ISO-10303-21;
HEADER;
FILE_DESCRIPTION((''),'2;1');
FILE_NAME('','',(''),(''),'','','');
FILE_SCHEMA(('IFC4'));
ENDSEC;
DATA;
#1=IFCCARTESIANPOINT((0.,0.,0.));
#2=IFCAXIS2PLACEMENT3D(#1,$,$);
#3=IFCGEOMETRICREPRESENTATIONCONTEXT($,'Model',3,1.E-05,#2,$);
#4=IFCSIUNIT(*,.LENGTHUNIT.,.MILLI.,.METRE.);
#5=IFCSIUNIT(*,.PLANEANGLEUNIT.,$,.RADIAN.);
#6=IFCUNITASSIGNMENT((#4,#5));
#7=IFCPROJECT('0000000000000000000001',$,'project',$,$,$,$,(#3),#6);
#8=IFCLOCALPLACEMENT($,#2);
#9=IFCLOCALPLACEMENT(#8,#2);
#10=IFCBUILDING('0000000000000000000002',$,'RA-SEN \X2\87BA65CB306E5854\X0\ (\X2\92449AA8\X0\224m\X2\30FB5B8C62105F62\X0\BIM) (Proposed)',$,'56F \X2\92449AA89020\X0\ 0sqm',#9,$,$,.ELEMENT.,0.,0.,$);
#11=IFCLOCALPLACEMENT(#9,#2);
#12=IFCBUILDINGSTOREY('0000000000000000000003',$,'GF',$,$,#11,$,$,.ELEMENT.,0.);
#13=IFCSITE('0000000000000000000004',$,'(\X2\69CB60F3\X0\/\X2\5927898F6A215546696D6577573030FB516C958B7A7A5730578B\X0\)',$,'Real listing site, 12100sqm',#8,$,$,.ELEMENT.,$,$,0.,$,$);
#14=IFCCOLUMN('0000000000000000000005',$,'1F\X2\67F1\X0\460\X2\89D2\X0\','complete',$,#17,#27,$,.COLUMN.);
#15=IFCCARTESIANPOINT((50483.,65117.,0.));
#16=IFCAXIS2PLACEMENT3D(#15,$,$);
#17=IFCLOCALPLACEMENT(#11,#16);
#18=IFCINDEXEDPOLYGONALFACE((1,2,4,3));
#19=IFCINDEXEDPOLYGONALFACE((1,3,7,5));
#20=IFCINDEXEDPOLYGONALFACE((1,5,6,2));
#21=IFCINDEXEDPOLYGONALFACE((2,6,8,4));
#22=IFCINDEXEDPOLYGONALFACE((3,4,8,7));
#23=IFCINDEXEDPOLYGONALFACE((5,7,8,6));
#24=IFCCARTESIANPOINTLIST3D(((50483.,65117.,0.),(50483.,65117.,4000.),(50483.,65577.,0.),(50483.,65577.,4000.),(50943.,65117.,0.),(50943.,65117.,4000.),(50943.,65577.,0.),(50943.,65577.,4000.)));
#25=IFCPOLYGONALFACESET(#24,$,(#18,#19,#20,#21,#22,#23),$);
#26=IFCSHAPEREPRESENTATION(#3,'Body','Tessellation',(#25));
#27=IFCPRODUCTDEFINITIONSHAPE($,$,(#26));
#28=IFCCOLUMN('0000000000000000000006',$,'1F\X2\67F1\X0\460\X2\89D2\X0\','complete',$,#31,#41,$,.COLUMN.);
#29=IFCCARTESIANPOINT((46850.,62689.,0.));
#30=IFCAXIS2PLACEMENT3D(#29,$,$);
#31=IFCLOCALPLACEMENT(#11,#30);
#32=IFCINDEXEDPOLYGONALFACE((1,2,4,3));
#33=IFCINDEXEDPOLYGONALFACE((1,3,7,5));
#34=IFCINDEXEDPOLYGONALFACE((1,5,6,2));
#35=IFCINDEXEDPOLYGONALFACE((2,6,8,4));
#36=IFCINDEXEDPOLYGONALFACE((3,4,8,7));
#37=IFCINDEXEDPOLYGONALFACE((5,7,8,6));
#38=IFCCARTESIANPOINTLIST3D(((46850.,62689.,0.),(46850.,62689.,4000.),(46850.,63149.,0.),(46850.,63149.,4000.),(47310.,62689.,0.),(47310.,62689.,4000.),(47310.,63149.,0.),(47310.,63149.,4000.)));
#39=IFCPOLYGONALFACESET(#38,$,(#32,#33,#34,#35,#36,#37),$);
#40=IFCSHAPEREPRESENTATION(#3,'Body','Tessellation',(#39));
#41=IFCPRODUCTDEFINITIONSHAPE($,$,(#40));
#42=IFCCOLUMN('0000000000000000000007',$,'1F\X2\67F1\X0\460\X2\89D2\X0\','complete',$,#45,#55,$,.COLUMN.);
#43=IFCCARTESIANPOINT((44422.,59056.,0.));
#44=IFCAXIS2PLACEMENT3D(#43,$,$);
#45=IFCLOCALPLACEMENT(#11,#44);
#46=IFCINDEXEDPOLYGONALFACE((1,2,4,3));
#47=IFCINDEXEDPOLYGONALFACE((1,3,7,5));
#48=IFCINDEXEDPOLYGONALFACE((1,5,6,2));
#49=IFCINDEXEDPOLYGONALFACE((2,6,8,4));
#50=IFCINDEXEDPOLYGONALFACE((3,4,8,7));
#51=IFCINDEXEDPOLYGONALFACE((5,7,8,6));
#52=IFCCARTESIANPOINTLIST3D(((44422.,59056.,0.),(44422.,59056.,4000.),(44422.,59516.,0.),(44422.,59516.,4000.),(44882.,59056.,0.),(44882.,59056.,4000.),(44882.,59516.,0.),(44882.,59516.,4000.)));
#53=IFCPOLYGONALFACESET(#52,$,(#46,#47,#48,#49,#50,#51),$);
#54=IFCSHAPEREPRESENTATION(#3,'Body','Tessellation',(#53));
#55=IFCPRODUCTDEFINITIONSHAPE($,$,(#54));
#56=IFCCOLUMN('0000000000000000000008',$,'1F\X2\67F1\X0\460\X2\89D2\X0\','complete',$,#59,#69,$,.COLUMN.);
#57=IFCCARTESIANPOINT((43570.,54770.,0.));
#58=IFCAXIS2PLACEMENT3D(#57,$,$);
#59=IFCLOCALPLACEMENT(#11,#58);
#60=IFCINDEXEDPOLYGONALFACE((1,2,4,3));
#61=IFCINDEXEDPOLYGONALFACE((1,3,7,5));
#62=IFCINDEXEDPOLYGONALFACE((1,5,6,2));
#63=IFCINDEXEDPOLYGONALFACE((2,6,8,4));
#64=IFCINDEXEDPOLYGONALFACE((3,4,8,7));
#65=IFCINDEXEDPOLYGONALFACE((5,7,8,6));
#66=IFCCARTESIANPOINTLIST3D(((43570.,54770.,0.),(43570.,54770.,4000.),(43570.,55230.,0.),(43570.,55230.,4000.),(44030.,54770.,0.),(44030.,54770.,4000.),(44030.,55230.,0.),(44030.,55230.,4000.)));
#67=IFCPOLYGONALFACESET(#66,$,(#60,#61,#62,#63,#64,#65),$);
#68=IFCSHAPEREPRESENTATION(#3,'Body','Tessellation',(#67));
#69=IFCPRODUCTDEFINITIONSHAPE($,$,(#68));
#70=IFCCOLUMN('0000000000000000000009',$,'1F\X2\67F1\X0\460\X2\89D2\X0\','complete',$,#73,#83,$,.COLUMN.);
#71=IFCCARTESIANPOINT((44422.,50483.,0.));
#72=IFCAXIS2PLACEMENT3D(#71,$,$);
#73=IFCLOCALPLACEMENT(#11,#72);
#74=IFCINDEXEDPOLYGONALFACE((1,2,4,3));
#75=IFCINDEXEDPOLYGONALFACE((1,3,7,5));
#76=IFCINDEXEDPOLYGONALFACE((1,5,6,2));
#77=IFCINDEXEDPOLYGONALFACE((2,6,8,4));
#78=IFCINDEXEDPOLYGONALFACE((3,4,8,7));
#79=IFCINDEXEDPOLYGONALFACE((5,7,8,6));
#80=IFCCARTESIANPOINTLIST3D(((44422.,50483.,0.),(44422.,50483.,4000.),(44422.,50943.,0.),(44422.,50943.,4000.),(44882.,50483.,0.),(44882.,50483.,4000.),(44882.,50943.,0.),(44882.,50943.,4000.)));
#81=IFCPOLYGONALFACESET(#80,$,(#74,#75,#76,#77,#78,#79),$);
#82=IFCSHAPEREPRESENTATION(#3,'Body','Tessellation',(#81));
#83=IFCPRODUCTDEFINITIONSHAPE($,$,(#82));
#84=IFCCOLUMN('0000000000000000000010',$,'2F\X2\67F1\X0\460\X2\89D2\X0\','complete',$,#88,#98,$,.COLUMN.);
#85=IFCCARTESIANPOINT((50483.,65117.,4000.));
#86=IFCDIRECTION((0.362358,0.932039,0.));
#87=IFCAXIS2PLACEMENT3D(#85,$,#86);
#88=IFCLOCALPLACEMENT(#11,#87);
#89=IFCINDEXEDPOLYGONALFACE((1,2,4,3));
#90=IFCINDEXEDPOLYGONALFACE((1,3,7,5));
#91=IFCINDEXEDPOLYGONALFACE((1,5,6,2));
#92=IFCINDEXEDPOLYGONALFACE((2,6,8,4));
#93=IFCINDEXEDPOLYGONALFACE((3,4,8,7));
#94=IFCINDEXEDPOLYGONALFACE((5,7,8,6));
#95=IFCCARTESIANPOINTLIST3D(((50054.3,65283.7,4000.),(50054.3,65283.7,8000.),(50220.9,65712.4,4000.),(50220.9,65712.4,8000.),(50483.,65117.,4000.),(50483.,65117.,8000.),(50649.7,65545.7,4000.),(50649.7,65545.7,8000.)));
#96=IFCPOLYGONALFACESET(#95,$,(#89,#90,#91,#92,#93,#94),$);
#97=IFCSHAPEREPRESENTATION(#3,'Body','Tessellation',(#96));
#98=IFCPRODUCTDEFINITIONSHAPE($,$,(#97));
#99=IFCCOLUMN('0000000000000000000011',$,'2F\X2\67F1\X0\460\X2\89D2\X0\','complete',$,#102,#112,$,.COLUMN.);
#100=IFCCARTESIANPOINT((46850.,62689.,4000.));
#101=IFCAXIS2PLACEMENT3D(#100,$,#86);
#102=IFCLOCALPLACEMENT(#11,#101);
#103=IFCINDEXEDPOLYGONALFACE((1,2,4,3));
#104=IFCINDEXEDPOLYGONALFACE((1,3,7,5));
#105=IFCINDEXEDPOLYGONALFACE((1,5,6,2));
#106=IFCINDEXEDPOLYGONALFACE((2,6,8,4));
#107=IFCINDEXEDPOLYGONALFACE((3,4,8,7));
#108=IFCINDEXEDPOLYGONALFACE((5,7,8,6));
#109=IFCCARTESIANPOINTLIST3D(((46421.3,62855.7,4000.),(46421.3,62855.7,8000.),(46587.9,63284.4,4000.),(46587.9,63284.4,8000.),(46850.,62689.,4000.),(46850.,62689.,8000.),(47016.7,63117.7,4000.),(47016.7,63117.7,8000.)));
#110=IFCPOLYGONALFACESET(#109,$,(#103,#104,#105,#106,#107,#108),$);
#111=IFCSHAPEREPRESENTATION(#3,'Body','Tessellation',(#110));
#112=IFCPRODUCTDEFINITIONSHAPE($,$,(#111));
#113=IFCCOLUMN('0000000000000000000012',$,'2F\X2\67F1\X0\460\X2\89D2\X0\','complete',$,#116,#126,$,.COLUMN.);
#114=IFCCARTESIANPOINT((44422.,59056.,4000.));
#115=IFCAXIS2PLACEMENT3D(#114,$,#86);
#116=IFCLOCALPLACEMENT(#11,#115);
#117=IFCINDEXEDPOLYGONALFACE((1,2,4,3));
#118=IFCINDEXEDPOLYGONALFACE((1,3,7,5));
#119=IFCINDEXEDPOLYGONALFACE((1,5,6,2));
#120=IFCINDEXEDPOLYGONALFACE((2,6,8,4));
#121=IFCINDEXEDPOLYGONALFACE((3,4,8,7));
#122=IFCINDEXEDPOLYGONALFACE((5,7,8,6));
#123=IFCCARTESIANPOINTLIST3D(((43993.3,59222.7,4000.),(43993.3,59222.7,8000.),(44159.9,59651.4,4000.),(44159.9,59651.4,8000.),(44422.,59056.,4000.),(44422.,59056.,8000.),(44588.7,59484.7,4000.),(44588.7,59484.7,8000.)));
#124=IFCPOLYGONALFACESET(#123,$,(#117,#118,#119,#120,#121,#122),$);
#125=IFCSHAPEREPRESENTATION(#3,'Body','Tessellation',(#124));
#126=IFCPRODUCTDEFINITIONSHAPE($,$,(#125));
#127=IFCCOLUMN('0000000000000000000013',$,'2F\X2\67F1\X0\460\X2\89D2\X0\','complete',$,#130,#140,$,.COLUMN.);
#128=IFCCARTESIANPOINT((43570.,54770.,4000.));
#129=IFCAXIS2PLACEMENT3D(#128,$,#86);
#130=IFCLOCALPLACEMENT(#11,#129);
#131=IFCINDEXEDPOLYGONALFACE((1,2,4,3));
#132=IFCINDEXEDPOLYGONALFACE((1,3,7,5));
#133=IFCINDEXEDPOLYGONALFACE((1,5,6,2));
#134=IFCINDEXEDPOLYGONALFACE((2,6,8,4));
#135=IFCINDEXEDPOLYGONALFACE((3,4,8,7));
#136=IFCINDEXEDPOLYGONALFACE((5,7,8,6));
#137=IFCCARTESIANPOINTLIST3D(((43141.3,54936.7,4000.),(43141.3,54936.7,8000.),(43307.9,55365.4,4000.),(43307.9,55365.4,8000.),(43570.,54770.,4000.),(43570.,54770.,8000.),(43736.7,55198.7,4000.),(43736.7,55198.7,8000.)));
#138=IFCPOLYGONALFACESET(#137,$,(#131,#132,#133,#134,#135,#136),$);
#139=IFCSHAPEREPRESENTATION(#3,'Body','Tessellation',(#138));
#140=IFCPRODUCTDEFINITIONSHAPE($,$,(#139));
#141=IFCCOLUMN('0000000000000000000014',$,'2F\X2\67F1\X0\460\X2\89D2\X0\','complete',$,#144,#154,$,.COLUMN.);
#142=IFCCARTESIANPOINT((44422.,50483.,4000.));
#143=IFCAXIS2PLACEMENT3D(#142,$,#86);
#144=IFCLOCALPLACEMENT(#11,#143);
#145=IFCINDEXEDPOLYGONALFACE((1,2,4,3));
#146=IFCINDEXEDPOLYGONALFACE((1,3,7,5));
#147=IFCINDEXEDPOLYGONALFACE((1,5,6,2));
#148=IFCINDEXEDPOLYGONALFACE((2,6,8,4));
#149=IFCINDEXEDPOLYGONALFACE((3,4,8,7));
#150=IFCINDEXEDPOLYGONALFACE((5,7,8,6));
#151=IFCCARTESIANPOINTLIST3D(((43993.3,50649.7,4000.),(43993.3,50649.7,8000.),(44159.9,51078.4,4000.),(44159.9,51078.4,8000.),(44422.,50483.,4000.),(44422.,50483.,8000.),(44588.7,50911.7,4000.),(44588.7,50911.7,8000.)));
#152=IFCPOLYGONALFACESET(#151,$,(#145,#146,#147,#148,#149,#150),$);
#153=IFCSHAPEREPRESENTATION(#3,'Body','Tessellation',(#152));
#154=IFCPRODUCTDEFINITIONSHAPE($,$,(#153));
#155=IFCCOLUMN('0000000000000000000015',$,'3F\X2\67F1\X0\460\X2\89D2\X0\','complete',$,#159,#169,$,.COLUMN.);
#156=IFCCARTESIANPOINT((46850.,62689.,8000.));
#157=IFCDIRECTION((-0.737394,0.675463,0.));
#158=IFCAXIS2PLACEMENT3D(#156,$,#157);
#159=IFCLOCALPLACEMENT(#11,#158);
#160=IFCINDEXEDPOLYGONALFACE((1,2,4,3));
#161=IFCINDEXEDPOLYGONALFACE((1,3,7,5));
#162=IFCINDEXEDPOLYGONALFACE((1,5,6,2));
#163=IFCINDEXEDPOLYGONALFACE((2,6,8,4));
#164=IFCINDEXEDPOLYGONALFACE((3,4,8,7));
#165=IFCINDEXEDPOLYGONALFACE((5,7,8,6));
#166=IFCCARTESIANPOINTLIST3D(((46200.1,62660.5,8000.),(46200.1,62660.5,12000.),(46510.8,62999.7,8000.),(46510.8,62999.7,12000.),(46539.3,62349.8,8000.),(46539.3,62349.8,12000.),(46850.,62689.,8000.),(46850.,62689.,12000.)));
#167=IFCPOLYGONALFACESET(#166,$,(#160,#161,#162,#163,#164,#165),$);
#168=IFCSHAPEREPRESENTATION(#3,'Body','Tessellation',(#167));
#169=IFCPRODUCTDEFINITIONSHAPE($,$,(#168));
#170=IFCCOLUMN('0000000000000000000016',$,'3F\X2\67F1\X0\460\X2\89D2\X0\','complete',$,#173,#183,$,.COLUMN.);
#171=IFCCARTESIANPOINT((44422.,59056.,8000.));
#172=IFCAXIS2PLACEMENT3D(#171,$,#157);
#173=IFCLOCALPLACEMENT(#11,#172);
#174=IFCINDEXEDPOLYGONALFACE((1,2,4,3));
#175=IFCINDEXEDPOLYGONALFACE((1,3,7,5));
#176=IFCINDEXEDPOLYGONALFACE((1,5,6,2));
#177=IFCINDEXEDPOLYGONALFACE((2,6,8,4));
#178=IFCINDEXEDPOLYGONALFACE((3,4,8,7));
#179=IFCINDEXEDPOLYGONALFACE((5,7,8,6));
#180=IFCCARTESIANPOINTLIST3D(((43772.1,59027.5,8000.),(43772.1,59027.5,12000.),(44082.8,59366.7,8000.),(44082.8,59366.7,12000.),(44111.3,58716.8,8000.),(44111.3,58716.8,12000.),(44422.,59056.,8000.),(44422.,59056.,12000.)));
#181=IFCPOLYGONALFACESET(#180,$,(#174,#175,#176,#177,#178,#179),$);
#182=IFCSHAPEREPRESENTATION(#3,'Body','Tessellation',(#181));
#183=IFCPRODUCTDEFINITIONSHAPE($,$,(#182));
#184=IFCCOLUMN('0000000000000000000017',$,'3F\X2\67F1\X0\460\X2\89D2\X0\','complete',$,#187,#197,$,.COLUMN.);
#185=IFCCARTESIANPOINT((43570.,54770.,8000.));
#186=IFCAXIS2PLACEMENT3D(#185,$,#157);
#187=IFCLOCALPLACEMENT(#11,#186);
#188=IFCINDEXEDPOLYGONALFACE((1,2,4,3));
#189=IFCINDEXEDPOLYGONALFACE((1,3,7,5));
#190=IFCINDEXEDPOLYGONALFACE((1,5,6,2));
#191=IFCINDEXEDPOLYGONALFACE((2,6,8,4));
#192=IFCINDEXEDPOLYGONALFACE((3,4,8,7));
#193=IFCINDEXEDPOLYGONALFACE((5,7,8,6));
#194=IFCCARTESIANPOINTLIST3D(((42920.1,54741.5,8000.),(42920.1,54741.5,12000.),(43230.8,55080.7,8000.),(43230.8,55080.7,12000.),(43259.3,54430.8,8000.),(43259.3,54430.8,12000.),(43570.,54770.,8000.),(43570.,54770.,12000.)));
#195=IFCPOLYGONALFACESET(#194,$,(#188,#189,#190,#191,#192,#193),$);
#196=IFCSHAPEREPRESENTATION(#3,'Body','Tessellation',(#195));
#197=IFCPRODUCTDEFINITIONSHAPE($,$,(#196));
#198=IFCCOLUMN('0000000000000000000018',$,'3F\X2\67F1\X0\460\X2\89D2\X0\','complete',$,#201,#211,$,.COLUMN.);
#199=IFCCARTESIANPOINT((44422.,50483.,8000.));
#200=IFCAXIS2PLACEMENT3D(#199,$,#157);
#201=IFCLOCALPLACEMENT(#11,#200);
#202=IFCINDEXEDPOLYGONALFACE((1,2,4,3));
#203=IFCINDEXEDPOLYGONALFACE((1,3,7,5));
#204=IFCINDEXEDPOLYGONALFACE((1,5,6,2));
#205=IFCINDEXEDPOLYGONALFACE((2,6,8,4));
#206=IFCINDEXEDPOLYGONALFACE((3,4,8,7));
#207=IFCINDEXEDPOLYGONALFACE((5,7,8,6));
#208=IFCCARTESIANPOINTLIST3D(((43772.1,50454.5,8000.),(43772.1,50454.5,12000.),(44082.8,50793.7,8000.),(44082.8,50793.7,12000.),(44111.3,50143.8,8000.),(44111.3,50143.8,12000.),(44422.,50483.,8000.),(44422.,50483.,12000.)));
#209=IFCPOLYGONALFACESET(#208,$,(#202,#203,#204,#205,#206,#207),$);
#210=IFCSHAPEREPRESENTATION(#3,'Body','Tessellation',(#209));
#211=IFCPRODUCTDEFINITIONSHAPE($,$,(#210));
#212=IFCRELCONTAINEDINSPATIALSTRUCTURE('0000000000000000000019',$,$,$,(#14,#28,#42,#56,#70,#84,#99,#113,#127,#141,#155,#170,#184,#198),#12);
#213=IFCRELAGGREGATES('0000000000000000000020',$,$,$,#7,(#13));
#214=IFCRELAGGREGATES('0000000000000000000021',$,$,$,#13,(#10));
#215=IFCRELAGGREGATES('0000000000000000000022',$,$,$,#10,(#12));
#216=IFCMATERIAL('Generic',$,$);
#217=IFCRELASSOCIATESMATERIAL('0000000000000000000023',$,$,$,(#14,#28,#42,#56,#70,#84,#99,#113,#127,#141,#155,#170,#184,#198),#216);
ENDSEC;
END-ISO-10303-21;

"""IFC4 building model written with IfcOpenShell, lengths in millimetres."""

from ifc_helpers import new_model, si_unit, frame, frame_2d, origin, place, context, project, spatial, rectangle, extrude, material, element, save


model = new_model("IFC4")

# Units and contexts
model_context = context("Model", 3, precision=1e-05, world=origin())
ifc_project = project(units=[si_unit("LENGTHUNIT", "METRE", prefix="MILLI"), si_unit("PLANEANGLEUNIT", "RADIAN")], contexts=[model_context])

# Site, building, storey
site_placement = place(None, origin())
site = spatial("IfcSite", under=ifc_project, at=site_placement, Name="(構想/大規模商業敷地・公開空地型)", ObjectType="Real listing site, 12100sqm", CompositionType="ELEMENT", RefElevation=0.0)
building_placement = place(site_placement, origin())
building = spatial("IfcBuilding", under=site, at=building_placement, Name="RA-SEN 螺旋の塔 (鉄骨224m・完成形BIM) (Proposed)", ObjectType="56F 鉄骨造 0sqm", CompositionType="ELEMENT", ElevationOfRefHeight=0.0, ElevationOfTerrain=0.0)
storey_placement = place(building_placement, origin())
storey = spatial("IfcBuildingStorey", under=building, at=storey_placement, Name="GF", CompositionType="ELEMENT", Elevation=0.0)

# Columns
ifc_material = material(Name="Generic")
column_1_placement = place(storey_placement, frame((50483.0, 65117.0, 0.0)))
element("IfcColumn", 1, at=column_1_placement, inside=storey, material=ifc_material, Name="1F柱460角", Description="complete", PredefinedType="COLUMN", context=model_context, shape_type="SweptSolid", body=[
    extrude(rectangle(XDim=460.0, YDim=460.0, at=frame_2d((230.0, 230.0))), frame((50483.0, 65117.0, 0.0)), (0.0, 0.0, 1.0), 4000.0),
])
column_2_placement = place(storey_placement, frame((46850.0, 62689.0, 0.0)))
element("IfcColumn", 2, at=column_2_placement, inside=storey, material=ifc_material, Name="1F柱460角", Description="complete", PredefinedType="COLUMN", context=model_context, shape_type="SweptSolid", body=[
    extrude(rectangle(XDim=460.0, YDim=460.0, at=frame_2d((230.0, 230.0))), frame((46850.0, 62689.0, 0.0)), (0.0, 0.0, 1.0), 4000.0),
])
column_3_placement = place(storey_placement, frame((44422.0, 59056.0, 0.0)))
element("IfcColumn", 3, at=column_3_placement, inside=storey, material=ifc_material, Name="1F柱460角", Description="complete", PredefinedType="COLUMN", context=model_context, shape_type="SweptSolid", body=[
    extrude(rectangle(XDim=460.0, YDim=460.0, at=frame_2d((230.0, 230.0))), frame((44422.0, 59056.0, 0.0)), (0.0, 0.0, 1.0), 4000.0),
])
column_4_placement = place(storey_placement, frame((43570.0, 54770.0, 0.0)))
element("IfcColumn", 4, at=column_4_placement, inside=storey, material=ifc_material, Name="1F柱460角", Description="complete", PredefinedType="COLUMN", context=model_context, shape_type="SweptSolid", body=[
    extrude(rectangle(XDim=460.0, YDim=460.0, at=frame_2d((230.0, 230.0))), frame((43570.0, 54770.0, 0.0)), (0.0, 0.0, 1.0), 4000.0),
])
column_5_placement = place(storey_placement, frame((44422.0, 50483.0, 0.0)))
element("IfcColumn", 5, at=column_5_placement, inside=storey, material=ifc_material, Name="1F柱460角", Description="complete", PredefinedType="COLUMN", context=model_context, shape_type="SweptSolid", body=[
    extrude(rectangle(XDim=460.0, YDim=460.0, at=frame_2d((230.0, 230.0))), frame((44422.0, 50483.0, 0.0)), (0.0, 0.0, 1.0), 4000.0),
])
column_6_placement = place(storey_placement, frame((50483.0, 65117.0, 4000.0), x_axis=(0.362358, 0.932039, 0.0)))
element("IfcColumn", 6, at=column_6_placement, inside=storey, material=ifc_material, Name="2F柱460角", Description="complete", PredefinedType="COLUMN", context=model_context, shape_type="SweptSolid", body=[
    extrude(rectangle(XDim=460.0, YDim=460.0, at=frame_2d((230.0, 230.0))), frame((50483.0, 65117.0, 4000.0), x_axis=(0.362358, 0.932039, 0.0)), (0.0, 0.0, 1.0), 4000.0),
])
column_7_placement = place(storey_placement, frame((46850.0, 62689.0, 4000.0), x_axis=(0.362358, 0.932039, 0.0)))
element("IfcColumn", 7, at=column_7_placement, inside=storey, material=ifc_material, Name="2F柱460角", Description="complete", PredefinedType="COLUMN", context=model_context, shape_type="SweptSolid", body=[
    extrude(rectangle(XDim=460.0, YDim=460.0, at=frame_2d((230.0, 230.0))), frame((46850.0, 62689.0, 4000.0), x_axis=(0.362358, 0.932039, 0.0)), (0.0, 0.0, 1.0), 4000.0),
])
column_8_placement = place(storey_placement, frame((44422.0, 59056.0, 4000.0), x_axis=(0.362358, 0.932039, 0.0)))
element("IfcColumn", 8, at=column_8_placement, inside=storey, material=ifc_material, Name="2F柱460角", Description="complete", PredefinedType="COLUMN", context=model_context, shape_type="SweptSolid", body=[
    extrude(rectangle(XDim=460.0, YDim=460.0, at=frame_2d((230.0, 230.0))), frame((44422.0, 59056.0, 4000.0), x_axis=(0.362358, 0.932039, 0.0)), (0.0, 0.0, 1.0), 4000.0),
])
column_9_placement = place(storey_placement, frame((43570.0, 54770.0, 4000.0), x_axis=(0.362358, 0.932039, 0.0)))
element("IfcColumn", 9, at=column_9_placement, inside=storey, material=ifc_material, Name="2F柱460角", Description="complete", PredefinedType="COLUMN", context=model_context, shape_type="SweptSolid", body=[
    extrude(rectangle(XDim=460.0, YDim=460.0, at=frame_2d((230.0, 230.0))), frame((43570.0, 54770.0, 4000.0), x_axis=(0.362358, 0.932039, 0.0)), (0.0, 0.0, 1.0), 4000.0),
])
column_10_placement = place(storey_placement, frame((44422.0, 50483.0, 4000.0), x_axis=(0.362358, 0.932039, 0.0)))
element("IfcColumn", 10, at=column_10_placement, inside=storey, material=ifc_material, Name="2F柱460角", Description="complete", PredefinedType="COLUMN", context=model_context, shape_type="SweptSolid", body=[
    extrude(rectangle(XDim=460.0, YDim=460.0, at=frame_2d((230.0, 230.0))), frame((44422.0, 50483.0, 4000.0), x_axis=(0.362358, 0.932039, 0.0)), (0.0, 0.0, 1.0), 4000.0),
])
column_11_placement = place(storey_placement, frame((46850.0, 62689.0, 8000.0), x_axis=(-0.737394, 0.675463, 0.0)))
element("IfcColumn", 11, at=column_11_placement, inside=storey, material=ifc_material, Name="3F柱460角", Description="complete", PredefinedType="COLUMN", context=model_context, shape_type="SweptSolid", body=[
    extrude(rectangle(XDim=460.0, YDim=460.0, at=frame_2d((230.0, 230.0))), frame((46850.0, 62689.0, 8000.0), x_axis=(-0.737394, 0.675463, 0.0)), (0.0, 0.0, 1.0), 4000.0),
])
column_12_placement = place(storey_placement, frame((44422.0, 59056.0, 8000.0), x_axis=(-0.737394, 0.675463, 0.0)))
element("IfcColumn", 12, at=column_12_placement, inside=storey, material=ifc_material, Name="3F柱460角", Description="complete", PredefinedType="COLUMN", context=model_context, shape_type="SweptSolid", body=[
    extrude(rectangle(XDim=460.0, YDim=460.0, at=frame_2d((230.0, 230.0))), frame((44422.0, 59056.0, 8000.0), x_axis=(-0.737394, 0.675463, 0.0)), (0.0, 0.0, 1.0), 4000.0),
])
column_13_placement = place(storey_placement, frame((43570.0, 54770.0, 8000.0), x_axis=(-0.737394, 0.675463, 0.0)))
element("IfcColumn", 13, at=column_13_placement, inside=storey, material=ifc_material, Name="3F柱460角", Description="complete", PredefinedType="COLUMN", context=model_context, shape_type="SweptSolid", body=[
    extrude(rectangle(XDim=460.0, YDim=460.0, at=frame_2d((230.0, 230.0))), frame((43570.0, 54770.0, 8000.0), x_axis=(-0.737394, 0.675463, 0.0)), (0.0, 0.0, 1.0), 4000.0),
])
column_14_placement = place(storey_placement, frame((44422.0, 50483.0, 8000.0), x_axis=(-0.737394, 0.675463, 0.0)))
element("IfcColumn", 14, at=column_14_placement, inside=storey, material=ifc_material, Name="3F柱460角", Description="complete", PredefinedType="COLUMN", context=model_context, shape_type="SweptSolid", body=[
    extrude(rectangle(XDim=460.0, YDim=460.0, at=frame_2d((230.0, 230.0))), frame((44422.0, 50483.0, 8000.0), x_axis=(-0.737394, 0.675463, 0.0)), (0.0, 0.0, 1.0), 4000.0),
])

save(model, "model.ifc")
